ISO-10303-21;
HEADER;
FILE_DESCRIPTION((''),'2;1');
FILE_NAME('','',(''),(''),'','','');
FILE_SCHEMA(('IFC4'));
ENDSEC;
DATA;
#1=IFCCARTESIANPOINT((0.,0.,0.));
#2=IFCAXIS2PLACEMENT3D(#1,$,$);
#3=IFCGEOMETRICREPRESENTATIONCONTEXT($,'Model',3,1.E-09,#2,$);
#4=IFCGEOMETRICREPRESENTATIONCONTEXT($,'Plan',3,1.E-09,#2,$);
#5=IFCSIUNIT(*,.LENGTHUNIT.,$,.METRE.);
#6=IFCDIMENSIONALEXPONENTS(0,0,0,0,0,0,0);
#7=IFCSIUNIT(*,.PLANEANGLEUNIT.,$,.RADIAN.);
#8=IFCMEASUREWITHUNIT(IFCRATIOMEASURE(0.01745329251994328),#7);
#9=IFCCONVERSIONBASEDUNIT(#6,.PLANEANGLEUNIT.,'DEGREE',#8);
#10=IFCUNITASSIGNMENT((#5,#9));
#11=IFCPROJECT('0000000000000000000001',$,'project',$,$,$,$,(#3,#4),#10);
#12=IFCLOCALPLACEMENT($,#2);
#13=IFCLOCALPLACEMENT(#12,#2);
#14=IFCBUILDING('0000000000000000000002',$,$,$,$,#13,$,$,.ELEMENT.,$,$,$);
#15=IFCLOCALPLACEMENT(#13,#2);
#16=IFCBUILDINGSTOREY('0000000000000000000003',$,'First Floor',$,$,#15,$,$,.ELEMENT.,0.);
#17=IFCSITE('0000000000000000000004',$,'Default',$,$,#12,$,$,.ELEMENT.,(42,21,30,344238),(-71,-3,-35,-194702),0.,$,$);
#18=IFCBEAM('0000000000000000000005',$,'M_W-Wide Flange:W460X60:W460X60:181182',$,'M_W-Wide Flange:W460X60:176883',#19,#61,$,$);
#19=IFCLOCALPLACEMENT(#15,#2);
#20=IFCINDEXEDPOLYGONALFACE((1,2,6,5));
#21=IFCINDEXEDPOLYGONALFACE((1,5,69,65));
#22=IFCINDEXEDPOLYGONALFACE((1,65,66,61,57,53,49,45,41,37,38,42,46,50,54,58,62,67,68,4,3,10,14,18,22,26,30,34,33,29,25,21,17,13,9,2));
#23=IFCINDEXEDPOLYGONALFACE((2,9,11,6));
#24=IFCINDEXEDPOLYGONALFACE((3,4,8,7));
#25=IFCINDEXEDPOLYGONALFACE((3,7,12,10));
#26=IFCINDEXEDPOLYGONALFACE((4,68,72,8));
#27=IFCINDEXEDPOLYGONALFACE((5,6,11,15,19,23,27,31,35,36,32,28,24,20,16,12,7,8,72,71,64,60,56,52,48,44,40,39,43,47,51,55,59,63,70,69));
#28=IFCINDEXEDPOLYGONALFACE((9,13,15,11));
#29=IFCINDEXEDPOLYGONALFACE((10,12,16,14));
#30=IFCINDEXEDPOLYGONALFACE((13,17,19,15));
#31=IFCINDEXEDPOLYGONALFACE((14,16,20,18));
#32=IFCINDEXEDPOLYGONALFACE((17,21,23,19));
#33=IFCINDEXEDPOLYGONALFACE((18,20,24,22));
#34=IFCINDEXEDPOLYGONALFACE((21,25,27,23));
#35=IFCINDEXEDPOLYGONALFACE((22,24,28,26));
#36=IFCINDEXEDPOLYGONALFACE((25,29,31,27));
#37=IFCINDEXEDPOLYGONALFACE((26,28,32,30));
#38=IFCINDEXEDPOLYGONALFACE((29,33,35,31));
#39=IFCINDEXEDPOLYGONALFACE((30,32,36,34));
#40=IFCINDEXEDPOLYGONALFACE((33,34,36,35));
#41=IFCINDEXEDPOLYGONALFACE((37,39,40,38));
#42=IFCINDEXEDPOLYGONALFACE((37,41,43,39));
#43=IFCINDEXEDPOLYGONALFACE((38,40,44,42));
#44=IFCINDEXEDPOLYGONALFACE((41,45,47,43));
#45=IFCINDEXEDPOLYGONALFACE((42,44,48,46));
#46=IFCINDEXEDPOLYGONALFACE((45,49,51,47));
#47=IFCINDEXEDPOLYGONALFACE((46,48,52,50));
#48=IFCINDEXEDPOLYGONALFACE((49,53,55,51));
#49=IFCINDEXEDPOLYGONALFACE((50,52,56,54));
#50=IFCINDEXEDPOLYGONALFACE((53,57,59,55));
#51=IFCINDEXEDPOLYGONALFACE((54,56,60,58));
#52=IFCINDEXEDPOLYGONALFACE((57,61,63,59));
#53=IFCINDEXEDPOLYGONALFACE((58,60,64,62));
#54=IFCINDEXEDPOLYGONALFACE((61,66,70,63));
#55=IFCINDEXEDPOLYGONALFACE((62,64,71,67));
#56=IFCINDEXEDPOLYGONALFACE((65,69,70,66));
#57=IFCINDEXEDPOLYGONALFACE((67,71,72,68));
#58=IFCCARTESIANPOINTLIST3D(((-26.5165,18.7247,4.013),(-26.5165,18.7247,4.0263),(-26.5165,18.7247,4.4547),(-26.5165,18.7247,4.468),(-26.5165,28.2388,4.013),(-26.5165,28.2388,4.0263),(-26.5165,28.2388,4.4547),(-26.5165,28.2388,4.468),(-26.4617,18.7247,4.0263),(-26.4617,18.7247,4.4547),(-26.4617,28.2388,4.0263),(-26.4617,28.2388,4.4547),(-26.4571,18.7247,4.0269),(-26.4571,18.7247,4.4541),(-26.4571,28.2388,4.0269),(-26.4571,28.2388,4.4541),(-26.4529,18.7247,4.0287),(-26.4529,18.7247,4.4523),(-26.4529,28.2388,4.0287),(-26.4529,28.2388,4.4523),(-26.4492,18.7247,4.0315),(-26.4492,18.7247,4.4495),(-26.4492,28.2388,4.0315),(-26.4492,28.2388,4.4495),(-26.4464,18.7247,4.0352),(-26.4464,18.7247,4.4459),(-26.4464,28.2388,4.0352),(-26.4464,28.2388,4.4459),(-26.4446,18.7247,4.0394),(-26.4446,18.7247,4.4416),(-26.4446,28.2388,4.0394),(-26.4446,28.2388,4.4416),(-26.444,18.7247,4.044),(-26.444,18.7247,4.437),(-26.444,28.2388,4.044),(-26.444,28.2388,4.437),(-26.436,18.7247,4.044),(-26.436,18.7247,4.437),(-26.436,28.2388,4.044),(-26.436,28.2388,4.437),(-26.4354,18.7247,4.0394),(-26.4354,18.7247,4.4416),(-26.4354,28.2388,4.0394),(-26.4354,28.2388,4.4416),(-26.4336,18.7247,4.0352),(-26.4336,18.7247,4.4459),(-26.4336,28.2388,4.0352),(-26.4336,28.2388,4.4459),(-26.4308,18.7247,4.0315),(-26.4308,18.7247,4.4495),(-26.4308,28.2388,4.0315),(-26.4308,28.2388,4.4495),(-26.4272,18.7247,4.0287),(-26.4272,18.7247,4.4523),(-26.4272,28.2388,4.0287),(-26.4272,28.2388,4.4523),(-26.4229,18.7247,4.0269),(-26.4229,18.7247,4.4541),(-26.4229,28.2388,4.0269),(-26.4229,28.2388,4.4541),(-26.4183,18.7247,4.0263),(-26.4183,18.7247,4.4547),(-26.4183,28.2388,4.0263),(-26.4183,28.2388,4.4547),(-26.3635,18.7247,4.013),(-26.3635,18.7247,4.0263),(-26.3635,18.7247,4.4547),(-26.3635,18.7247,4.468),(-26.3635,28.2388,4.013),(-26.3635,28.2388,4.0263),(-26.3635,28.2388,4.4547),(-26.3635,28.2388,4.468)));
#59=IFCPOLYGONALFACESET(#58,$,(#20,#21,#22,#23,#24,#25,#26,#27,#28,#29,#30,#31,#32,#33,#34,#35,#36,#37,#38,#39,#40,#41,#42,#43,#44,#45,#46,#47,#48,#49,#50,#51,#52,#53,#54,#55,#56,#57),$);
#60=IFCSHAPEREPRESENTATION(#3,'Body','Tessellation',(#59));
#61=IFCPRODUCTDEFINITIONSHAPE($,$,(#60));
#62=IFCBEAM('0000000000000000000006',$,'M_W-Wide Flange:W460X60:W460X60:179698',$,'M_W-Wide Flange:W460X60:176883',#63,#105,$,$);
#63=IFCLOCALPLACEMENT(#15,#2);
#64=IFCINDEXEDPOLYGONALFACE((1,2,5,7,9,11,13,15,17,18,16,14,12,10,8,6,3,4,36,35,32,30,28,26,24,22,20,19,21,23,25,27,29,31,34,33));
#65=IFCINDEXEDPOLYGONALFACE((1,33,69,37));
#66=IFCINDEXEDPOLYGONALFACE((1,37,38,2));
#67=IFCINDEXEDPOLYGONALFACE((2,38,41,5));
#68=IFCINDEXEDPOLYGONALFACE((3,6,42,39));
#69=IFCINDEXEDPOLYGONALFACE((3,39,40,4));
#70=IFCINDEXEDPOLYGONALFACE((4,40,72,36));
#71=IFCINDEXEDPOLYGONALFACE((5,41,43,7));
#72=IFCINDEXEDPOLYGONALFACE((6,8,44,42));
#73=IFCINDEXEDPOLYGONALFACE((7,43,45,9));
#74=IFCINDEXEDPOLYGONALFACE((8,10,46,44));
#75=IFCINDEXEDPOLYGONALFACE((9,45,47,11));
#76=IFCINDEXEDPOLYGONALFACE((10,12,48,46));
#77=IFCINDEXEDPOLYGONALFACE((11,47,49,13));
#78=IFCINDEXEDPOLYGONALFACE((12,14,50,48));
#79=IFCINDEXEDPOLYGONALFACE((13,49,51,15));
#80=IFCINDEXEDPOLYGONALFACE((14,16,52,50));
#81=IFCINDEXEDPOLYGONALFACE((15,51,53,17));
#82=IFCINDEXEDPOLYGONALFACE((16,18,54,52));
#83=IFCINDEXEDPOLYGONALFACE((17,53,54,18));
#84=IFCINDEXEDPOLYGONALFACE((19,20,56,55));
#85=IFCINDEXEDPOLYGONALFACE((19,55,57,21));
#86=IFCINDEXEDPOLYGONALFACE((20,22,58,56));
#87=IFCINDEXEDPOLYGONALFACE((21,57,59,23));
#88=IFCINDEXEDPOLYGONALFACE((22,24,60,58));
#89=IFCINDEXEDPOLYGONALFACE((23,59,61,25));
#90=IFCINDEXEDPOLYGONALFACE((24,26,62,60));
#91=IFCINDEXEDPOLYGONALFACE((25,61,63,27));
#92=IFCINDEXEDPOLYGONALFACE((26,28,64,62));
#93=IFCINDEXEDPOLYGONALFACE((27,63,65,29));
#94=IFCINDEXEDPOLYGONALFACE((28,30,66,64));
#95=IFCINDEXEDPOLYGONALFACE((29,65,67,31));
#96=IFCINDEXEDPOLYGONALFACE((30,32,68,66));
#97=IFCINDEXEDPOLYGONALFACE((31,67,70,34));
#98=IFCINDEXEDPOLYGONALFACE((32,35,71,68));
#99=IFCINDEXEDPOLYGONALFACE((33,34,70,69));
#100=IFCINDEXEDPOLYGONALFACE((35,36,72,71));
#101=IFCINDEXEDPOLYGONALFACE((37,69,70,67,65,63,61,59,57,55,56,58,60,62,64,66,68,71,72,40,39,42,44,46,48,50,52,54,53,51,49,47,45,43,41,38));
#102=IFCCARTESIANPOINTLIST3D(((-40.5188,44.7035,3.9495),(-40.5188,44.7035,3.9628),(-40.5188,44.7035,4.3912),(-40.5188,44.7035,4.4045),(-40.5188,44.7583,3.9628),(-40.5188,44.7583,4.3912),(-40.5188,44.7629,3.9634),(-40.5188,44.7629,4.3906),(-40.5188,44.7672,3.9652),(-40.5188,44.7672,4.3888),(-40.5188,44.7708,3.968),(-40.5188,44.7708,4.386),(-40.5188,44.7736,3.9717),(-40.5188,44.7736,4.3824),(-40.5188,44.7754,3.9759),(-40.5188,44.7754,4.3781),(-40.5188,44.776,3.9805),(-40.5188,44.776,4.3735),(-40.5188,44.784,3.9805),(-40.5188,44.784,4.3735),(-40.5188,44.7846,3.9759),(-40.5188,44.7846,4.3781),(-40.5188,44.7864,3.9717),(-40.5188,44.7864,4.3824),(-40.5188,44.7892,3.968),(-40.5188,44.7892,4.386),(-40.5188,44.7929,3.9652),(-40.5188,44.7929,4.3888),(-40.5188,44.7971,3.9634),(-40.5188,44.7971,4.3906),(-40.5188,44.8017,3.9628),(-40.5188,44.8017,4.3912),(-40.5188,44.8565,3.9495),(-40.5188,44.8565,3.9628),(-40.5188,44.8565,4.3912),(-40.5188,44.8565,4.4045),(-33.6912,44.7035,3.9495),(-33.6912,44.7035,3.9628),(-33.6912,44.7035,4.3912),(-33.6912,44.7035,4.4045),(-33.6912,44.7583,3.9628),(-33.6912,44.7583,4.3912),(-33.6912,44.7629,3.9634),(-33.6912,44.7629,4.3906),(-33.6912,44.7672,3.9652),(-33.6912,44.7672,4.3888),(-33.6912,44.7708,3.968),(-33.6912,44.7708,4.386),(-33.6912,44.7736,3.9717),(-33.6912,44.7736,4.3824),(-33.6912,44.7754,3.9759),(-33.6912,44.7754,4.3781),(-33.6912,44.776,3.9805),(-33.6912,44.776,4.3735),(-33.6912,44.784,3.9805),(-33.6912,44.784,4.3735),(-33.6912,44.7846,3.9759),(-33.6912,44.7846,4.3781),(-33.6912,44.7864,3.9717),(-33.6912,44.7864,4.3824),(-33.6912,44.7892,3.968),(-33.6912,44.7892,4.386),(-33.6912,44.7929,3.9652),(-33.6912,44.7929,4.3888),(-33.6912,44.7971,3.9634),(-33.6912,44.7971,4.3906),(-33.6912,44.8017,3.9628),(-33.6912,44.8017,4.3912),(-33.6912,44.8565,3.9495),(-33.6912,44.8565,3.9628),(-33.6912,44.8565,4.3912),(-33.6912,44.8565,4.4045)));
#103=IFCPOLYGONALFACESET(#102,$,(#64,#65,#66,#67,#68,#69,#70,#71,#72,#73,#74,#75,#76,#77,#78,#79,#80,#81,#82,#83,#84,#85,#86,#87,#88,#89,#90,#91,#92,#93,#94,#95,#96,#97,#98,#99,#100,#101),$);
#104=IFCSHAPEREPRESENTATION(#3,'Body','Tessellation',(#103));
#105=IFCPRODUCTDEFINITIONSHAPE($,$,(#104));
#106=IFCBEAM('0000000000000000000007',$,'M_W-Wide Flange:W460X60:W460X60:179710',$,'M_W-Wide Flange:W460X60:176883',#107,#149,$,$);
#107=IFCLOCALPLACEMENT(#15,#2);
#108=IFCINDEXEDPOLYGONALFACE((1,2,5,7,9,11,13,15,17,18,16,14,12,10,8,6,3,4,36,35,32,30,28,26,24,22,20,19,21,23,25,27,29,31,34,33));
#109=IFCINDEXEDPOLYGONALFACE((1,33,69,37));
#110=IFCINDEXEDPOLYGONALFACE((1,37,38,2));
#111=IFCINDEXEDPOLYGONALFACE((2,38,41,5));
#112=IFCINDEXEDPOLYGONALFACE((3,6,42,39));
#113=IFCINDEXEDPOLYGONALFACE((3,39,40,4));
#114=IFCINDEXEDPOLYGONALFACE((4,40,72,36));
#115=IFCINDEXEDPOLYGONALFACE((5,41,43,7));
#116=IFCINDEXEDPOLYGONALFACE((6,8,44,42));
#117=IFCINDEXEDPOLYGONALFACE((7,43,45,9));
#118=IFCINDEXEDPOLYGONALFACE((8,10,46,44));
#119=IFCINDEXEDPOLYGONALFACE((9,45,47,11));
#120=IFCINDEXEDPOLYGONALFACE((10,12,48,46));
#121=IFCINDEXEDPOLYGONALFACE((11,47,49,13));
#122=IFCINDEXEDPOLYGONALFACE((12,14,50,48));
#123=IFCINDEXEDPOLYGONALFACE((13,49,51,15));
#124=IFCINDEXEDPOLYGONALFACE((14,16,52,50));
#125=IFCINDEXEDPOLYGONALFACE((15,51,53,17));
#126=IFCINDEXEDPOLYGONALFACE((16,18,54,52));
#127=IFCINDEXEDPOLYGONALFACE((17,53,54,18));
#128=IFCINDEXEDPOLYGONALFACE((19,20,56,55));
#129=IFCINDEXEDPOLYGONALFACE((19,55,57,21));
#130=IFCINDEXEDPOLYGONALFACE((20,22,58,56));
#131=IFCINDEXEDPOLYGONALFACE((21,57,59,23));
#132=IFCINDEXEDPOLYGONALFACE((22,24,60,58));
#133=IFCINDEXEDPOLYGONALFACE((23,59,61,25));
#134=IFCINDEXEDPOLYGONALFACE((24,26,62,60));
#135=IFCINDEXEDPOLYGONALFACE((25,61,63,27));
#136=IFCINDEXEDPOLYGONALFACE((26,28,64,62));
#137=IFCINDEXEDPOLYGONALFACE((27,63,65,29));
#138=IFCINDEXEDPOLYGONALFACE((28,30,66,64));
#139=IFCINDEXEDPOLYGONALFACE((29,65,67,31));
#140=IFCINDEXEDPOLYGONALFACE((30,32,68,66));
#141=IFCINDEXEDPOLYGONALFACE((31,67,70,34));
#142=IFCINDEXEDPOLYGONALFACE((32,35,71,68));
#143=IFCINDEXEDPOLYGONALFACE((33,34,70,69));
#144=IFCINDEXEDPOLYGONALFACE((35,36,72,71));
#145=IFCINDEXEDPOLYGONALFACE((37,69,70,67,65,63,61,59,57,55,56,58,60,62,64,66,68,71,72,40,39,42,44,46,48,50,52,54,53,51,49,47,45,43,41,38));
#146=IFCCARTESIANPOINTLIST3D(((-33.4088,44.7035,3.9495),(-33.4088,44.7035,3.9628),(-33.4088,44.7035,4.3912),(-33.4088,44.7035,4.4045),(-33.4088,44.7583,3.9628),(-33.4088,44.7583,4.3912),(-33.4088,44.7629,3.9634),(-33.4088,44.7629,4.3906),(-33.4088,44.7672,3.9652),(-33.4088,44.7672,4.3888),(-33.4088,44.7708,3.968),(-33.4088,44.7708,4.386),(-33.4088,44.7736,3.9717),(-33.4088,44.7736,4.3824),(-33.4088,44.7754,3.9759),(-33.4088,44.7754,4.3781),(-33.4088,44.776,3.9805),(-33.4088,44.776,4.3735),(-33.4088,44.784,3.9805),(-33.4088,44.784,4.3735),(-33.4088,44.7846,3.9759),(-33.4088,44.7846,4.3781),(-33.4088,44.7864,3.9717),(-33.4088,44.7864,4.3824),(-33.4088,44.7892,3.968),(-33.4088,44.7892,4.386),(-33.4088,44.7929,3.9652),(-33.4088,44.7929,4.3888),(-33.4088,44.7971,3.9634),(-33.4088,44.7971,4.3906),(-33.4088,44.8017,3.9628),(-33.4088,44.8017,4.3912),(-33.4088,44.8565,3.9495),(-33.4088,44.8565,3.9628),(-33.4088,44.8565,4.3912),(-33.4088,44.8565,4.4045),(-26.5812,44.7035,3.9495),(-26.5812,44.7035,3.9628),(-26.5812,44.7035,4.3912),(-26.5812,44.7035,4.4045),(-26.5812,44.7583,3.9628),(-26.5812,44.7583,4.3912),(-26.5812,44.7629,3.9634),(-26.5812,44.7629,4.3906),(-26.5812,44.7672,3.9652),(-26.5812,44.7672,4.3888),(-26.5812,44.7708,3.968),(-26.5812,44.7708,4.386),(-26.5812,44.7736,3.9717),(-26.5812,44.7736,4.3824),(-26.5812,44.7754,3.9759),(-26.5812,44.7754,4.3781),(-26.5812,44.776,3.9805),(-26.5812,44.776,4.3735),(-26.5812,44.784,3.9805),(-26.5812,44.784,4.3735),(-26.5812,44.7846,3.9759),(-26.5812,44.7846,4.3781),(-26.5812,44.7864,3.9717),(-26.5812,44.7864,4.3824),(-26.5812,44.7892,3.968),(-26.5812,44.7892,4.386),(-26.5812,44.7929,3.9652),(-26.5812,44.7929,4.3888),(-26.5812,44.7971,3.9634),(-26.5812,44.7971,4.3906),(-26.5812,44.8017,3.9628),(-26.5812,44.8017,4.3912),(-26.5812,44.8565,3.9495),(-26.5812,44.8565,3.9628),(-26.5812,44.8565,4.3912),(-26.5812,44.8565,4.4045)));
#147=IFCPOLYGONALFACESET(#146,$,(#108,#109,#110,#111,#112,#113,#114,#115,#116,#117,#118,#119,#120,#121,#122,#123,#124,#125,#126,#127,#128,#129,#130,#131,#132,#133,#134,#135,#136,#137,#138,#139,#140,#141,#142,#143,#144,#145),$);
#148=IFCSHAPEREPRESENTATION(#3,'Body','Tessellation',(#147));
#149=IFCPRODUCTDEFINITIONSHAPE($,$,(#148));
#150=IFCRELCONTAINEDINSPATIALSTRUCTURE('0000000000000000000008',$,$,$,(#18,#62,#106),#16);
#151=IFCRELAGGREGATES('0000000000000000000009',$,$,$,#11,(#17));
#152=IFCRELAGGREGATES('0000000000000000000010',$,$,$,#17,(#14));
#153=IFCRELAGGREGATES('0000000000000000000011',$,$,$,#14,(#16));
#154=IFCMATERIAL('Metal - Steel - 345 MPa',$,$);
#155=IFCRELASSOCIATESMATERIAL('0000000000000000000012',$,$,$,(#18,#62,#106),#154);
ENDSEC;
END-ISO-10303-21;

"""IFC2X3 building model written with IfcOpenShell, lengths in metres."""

from ifc_helpers import new_model, entity, si_unit, converted_unit, frame, frame_2d, origin, place, context, project, spatial, polyline, circle_curve, parameter, trimmed, segment, composite_curve, outline, extrude, material, element, save


model = new_model("IFC2X3")

# Units and contexts
model_context = context("Model", 3, precision=1e-09, world=origin())
plan_context = context("Plan", 3, precision=1e-09, world=origin())
ifc_project = project(units=[si_unit("LENGTHUNIT", "METRE"), converted_unit("PLANEANGLEUNIT", "DEGREE", entity("IfcRatioMeasure", 0.01745329251994328), si_unit("PLANEANGLEUNIT", "RADIAN"), dimensions=[0, 0, 0, 0, 0, 0, 0])], contexts=[model_context, plan_context])

# Site, building, storey
site_placement = place(None, origin())
site = spatial("IfcSite", under=ifc_project, at=site_placement, Name="Default", CompositionType="ELEMENT", RefLatitude=(42, 21, 30, 344238), RefLongitude=(-71, -3, -35, -194702), RefElevation=0.0)
building_placement = place(site_placement, origin())
building = spatial("IfcBuilding", under=site, at=building_placement, CompositionType="ELEMENT")
storey_placement = place(building_placement, origin())
storey = spatial("IfcBuildingStorey", under=building, at=storey_placement, Name="First Floor", CompositionType="ELEMENT", Elevation=0.0)

# Beams
ifc_material = material(Name="Metal - Steel - 345 MPa")
beam_1_placement = place(storey_placement, frame((-26.44, 28.3814, 4.468), z_axis=(0.0, 0.0, 1.0), x_axis=(-1.0, 0.0, 0.0)))
element("IfcBeam", 1, at=beam_1_placement, inside=storey, material=ifc_material, Name="M_W-Wide Flange:W460X60:W460X60:181182", ObjectType="M_W-Wide Flange:W460X60:176883", context=model_context, shape_type="SweptSolid", body=[
    extrude(outline(composite_curve([segment(polyline([(0.2142, -0.0765), (0.2275, -0.0765)]), True, "CONTINUOUS"), segment(polyline([(0.2275, -0.0765), (0.2275, 0.0765)]), True, "CONTINUOUS"), segment(polyline([(0.2275, 0.0765), (0.2142, 0.0765)]), True, "CONTINUOUS"), segment(polyline([(0.2142, 0.0765), (0.2142, 0.0217)]), True, "CONTINUOUS"), segment(trimmed(circle_curve(frame_2d((0.1965, 0.0217), x_axis=(1.0, 0.0)), 0.0177), [parameter(270.0)], [parameter(360.0)], True, "PARAMETER"), False, "CONTINUOUS"), segment(polyline([(0.1965, 0.004), (-0.1965, 0.004)]), True, "CONTINUOUS"), segment(trimmed(circle_curve(frame_2d((-0.1965, 0.0217), x_axis=(0.0, -1.0)), 0.0177), [parameter(270.0)], [parameter(360.0)], True, "PARAMETER"), False, "CONTINUOUS"), segment(polyline([(-0.2142, 0.0217), (-0.2142, 0.0765)]), True, "CONTINUOUS"), segment(polyline([(-0.2142, 0.0765), (-0.2275, 0.0765)]), True, "CONTINUOUS"), segment(polyline([(-0.2275, 0.0765), (-0.2275, -0.0765)]), True, "CONTINUOUS"), segment(polyline([(-0.2275, -0.0765), (-0.2142, -0.0765)]), True, "CONTINUOUS"), segment(polyline([(-0.2142, -0.0765), (-0.2142, -0.0217)]), True, "CONTINUOUS"), segment(trimmed(circle_curve(frame_2d((-0.1965, -0.0217), x_axis=(-1.0, 0.0)), 0.0177), [parameter(270.0)], [parameter(360.0)], True, "PARAMETER"), False, "CONTINUOUS"), segment(polyline([(-0.1965, -0.004), (0.1965, -0.004)]), True, "CONTINUOUS"), segment(trimmed(circle_curve(frame_2d((0.1965, -0.0217), x_axis=(0.0, 1.0)), 0.0177), [parameter(270.0)], [parameter(0.0)], True, "PARAMETER"), False, "CONTINUOUS"), segment(polyline([(0.2142, -0.0217), (0.2142, -0.0765)]), True, "CONTINUOUS")], self_intersect=False)), frame((0.0, 9.6567, -0.2275), z_axis=(0.0, -1.0, 0.0), x_axis=(0.0, 0.0, -1.0)), (0.0, 0.0, 1.0), 9.5141),
])
beam_2_placement = place(storey_placement, frame((-40.6619, 44.78, 4.4045), z_axis=(0.0, 0.0, 1.0), x_axis=(0.0, -1.0, 0.0)))
element("IfcBeam", 2, at=beam_2_placement, inside=storey, material=ifc_material, Name="M_W-Wide Flange:W460X60:W460X60:179698", ObjectType="M_W-Wide Flange:W460X60:176883", context=model_context, shape_type="SweptSolid", body=[
    extrude(outline(composite_curve([segment(polyline([(-0.0765, -0.2142), (-0.0765, -0.2275)]), True, "CONTINUOUS"), segment(polyline([(-0.0765, -0.2275), (0.0765, -0.2275)]), True, "CONTINUOUS"), segment(polyline([(0.0765, -0.2275), (0.0765, -0.2142)]), True, "CONTINUOUS"), segment(polyline([(0.0765, -0.2142), (0.0217, -0.2142)]), True, "CONTINUOUS"), segment(trimmed(circle_curve(frame_2d((0.0217, -0.1965), x_axis=(0.0, -1.0)), 0.0177), [parameter(270.0)], [parameter(360.0)], True, "PARAMETER"), False, "CONTINUOUS"), segment(polyline([(0.004, -0.1965), (0.004, 0.1965)]), True, "CONTINUOUS"), segment(trimmed(circle_curve(frame_2d((0.0217, 0.1965), x_axis=(-1.0, 0.0)), 0.0177), [parameter(270.0)], [parameter(360.0)], True, "PARAMETER"), False, "CONTINUOUS"), segment(polyline([(0.0217, 0.2142), (0.0765, 0.2142)]), True, "CONTINUOUS"), segment(polyline([(0.0765, 0.2142), (0.0765, 0.2275)]), True, "CONTINUOUS"), segment(polyline([(0.0765, 0.2275), (-0.0765, 0.2275)]), True, "CONTINUOUS"), segment(polyline([(-0.0765, 0.2275), (-0.0765, 0.2142)]), True, "CONTINUOUS"), segment(polyline([(-0.0765, 0.2142), (-0.0217, 0.2142)]), True, "CONTINUOUS"), segment(trimmed(circle_curve(frame_2d((-0.0217, 0.1965), x_axis=(0.0, 1.0)), 0.0177), [parameter(270.0)], [parameter(360.0)], True, "PARAMETER"), False, "CONTINUOUS"), segment(polyline([(-0.004, 0.1965), (-0.004, -0.1965)]), True, "CONTINUOUS"), segment(trimmed(circle_curve(frame_2d((-0.0217, -0.1965), x_axis=(1.0, 0.0)), 0.0177), [parameter(270.0)], [parameter(0.0)], True, "PARAMETER"), False, "CONTINUOUS"), segment(polyline([(-0.0217, -0.2142), (-0.0765, -0.2142)]), True, "CONTINUOUS")], self_intersect=False)), frame((0.0, 0.1431, -0.2275), z_axis=(0.0, -1.0, 0.0), x_axis=(1.0, 0.0, 0.0)), (0.0, 0.0, -1.0), 6.8276),
])
beam_3_placement = place(storey_placement, frame((-33.5519, 44.78, 4.4045), z_axis=(0.0, 0.0, 1.0), x_axis=(0.0, -1.0, 0.0)))
element("IfcBeam", 3, at=beam_3_placement, inside=storey, material=ifc_material, Name="M_W-Wide Flange:W460X60:W460X60:179710", ObjectType="M_W-Wide Flange:W460X60:176883", context=model_context, shape_type="SweptSolid", body=[
    extrude(outline(composite_curve([segment(polyline([(-0.0765, -0.2142), (-0.0765, -0.2275)]), True, "CONTINUOUS"), segment(polyline([(-0.0765, -0.2275), (0.0765, -0.2275)]), True, "CONTINUOUS"), segment(polyline([(0.0765, -0.2275), (0.0765, -0.2142)]), True, "CONTINUOUS"), segment(polyline([(0.0765, -0.2142), (0.0217, -0.2142)]), True, "CONTINUOUS"), segment(trimmed(circle_curve(frame_2d((0.0217, -0.1965), x_axis=(0.0, -1.0)), 0.0177), [parameter(270.0)], [parameter(360.0)], True, "PARAMETER"), False, "CONTINUOUS"), segment(polyline([(0.004, -0.1965), (0.004, 0.1965)]), True, "CONTINUOUS"), segment(trimmed(circle_curve(frame_2d((0.0217, 0.1965), x_axis=(-1.0, 0.0)), 0.0177), [parameter(270.0)], [parameter(360.0)], True, "PARAMETER"), False, "CONTINUOUS"), segment(polyline([(0.0217, 0.2142), (0.0765, 0.2142)]), True, "CONTINUOUS"), segment(polyline([(0.0765, 0.2142), (0.0765, 0.2275)]), True, "CONTINUOUS"), segment(polyline([(0.0765, 0.2275), (-0.0765, 0.2275)]), True, "CONTINUOUS"), segment(polyline([(-0.0765, 0.2275), (-0.0765, 0.2142)]), True, "CONTINUOUS"), segment(polyline([(-0.0765, 0.2142), (-0.0217, 0.2142)]), True, "CONTINUOUS"), segment(trimmed(circle_curve(frame_2d((-0.0217, 0.1965), x_axis=(0.0, 1.0)), 0.0177), [parameter(270.0)], [parameter(360.0)], True, "PARAMETER"), False, "CONTINUOUS"), segment(polyline([(-0.004, 0.1965), (-0.004, -0.1965)]), True, "CONTINUOUS"), segment(trimmed(circle_curve(frame_2d((-0.0217, -0.1965), x_axis=(1.0, 0.0)), 0.0177), [parameter(270.0)], [parameter(0.0)], True, "PARAMETER"), False, "CONTINUOUS"), segment(polyline([(-0.0217, -0.2142), (-0.0765, -0.2142)]), True, "CONTINUOUS")], self_intersect=False)), frame((0.0, 0.1431, -0.2275), z_axis=(0.0, -1.0, 0.0), x_axis=(1.0, 0.0, 0.0)), (0.0, 0.0, -1.0), 6.8276),
])

save(model, "model.ifc")
